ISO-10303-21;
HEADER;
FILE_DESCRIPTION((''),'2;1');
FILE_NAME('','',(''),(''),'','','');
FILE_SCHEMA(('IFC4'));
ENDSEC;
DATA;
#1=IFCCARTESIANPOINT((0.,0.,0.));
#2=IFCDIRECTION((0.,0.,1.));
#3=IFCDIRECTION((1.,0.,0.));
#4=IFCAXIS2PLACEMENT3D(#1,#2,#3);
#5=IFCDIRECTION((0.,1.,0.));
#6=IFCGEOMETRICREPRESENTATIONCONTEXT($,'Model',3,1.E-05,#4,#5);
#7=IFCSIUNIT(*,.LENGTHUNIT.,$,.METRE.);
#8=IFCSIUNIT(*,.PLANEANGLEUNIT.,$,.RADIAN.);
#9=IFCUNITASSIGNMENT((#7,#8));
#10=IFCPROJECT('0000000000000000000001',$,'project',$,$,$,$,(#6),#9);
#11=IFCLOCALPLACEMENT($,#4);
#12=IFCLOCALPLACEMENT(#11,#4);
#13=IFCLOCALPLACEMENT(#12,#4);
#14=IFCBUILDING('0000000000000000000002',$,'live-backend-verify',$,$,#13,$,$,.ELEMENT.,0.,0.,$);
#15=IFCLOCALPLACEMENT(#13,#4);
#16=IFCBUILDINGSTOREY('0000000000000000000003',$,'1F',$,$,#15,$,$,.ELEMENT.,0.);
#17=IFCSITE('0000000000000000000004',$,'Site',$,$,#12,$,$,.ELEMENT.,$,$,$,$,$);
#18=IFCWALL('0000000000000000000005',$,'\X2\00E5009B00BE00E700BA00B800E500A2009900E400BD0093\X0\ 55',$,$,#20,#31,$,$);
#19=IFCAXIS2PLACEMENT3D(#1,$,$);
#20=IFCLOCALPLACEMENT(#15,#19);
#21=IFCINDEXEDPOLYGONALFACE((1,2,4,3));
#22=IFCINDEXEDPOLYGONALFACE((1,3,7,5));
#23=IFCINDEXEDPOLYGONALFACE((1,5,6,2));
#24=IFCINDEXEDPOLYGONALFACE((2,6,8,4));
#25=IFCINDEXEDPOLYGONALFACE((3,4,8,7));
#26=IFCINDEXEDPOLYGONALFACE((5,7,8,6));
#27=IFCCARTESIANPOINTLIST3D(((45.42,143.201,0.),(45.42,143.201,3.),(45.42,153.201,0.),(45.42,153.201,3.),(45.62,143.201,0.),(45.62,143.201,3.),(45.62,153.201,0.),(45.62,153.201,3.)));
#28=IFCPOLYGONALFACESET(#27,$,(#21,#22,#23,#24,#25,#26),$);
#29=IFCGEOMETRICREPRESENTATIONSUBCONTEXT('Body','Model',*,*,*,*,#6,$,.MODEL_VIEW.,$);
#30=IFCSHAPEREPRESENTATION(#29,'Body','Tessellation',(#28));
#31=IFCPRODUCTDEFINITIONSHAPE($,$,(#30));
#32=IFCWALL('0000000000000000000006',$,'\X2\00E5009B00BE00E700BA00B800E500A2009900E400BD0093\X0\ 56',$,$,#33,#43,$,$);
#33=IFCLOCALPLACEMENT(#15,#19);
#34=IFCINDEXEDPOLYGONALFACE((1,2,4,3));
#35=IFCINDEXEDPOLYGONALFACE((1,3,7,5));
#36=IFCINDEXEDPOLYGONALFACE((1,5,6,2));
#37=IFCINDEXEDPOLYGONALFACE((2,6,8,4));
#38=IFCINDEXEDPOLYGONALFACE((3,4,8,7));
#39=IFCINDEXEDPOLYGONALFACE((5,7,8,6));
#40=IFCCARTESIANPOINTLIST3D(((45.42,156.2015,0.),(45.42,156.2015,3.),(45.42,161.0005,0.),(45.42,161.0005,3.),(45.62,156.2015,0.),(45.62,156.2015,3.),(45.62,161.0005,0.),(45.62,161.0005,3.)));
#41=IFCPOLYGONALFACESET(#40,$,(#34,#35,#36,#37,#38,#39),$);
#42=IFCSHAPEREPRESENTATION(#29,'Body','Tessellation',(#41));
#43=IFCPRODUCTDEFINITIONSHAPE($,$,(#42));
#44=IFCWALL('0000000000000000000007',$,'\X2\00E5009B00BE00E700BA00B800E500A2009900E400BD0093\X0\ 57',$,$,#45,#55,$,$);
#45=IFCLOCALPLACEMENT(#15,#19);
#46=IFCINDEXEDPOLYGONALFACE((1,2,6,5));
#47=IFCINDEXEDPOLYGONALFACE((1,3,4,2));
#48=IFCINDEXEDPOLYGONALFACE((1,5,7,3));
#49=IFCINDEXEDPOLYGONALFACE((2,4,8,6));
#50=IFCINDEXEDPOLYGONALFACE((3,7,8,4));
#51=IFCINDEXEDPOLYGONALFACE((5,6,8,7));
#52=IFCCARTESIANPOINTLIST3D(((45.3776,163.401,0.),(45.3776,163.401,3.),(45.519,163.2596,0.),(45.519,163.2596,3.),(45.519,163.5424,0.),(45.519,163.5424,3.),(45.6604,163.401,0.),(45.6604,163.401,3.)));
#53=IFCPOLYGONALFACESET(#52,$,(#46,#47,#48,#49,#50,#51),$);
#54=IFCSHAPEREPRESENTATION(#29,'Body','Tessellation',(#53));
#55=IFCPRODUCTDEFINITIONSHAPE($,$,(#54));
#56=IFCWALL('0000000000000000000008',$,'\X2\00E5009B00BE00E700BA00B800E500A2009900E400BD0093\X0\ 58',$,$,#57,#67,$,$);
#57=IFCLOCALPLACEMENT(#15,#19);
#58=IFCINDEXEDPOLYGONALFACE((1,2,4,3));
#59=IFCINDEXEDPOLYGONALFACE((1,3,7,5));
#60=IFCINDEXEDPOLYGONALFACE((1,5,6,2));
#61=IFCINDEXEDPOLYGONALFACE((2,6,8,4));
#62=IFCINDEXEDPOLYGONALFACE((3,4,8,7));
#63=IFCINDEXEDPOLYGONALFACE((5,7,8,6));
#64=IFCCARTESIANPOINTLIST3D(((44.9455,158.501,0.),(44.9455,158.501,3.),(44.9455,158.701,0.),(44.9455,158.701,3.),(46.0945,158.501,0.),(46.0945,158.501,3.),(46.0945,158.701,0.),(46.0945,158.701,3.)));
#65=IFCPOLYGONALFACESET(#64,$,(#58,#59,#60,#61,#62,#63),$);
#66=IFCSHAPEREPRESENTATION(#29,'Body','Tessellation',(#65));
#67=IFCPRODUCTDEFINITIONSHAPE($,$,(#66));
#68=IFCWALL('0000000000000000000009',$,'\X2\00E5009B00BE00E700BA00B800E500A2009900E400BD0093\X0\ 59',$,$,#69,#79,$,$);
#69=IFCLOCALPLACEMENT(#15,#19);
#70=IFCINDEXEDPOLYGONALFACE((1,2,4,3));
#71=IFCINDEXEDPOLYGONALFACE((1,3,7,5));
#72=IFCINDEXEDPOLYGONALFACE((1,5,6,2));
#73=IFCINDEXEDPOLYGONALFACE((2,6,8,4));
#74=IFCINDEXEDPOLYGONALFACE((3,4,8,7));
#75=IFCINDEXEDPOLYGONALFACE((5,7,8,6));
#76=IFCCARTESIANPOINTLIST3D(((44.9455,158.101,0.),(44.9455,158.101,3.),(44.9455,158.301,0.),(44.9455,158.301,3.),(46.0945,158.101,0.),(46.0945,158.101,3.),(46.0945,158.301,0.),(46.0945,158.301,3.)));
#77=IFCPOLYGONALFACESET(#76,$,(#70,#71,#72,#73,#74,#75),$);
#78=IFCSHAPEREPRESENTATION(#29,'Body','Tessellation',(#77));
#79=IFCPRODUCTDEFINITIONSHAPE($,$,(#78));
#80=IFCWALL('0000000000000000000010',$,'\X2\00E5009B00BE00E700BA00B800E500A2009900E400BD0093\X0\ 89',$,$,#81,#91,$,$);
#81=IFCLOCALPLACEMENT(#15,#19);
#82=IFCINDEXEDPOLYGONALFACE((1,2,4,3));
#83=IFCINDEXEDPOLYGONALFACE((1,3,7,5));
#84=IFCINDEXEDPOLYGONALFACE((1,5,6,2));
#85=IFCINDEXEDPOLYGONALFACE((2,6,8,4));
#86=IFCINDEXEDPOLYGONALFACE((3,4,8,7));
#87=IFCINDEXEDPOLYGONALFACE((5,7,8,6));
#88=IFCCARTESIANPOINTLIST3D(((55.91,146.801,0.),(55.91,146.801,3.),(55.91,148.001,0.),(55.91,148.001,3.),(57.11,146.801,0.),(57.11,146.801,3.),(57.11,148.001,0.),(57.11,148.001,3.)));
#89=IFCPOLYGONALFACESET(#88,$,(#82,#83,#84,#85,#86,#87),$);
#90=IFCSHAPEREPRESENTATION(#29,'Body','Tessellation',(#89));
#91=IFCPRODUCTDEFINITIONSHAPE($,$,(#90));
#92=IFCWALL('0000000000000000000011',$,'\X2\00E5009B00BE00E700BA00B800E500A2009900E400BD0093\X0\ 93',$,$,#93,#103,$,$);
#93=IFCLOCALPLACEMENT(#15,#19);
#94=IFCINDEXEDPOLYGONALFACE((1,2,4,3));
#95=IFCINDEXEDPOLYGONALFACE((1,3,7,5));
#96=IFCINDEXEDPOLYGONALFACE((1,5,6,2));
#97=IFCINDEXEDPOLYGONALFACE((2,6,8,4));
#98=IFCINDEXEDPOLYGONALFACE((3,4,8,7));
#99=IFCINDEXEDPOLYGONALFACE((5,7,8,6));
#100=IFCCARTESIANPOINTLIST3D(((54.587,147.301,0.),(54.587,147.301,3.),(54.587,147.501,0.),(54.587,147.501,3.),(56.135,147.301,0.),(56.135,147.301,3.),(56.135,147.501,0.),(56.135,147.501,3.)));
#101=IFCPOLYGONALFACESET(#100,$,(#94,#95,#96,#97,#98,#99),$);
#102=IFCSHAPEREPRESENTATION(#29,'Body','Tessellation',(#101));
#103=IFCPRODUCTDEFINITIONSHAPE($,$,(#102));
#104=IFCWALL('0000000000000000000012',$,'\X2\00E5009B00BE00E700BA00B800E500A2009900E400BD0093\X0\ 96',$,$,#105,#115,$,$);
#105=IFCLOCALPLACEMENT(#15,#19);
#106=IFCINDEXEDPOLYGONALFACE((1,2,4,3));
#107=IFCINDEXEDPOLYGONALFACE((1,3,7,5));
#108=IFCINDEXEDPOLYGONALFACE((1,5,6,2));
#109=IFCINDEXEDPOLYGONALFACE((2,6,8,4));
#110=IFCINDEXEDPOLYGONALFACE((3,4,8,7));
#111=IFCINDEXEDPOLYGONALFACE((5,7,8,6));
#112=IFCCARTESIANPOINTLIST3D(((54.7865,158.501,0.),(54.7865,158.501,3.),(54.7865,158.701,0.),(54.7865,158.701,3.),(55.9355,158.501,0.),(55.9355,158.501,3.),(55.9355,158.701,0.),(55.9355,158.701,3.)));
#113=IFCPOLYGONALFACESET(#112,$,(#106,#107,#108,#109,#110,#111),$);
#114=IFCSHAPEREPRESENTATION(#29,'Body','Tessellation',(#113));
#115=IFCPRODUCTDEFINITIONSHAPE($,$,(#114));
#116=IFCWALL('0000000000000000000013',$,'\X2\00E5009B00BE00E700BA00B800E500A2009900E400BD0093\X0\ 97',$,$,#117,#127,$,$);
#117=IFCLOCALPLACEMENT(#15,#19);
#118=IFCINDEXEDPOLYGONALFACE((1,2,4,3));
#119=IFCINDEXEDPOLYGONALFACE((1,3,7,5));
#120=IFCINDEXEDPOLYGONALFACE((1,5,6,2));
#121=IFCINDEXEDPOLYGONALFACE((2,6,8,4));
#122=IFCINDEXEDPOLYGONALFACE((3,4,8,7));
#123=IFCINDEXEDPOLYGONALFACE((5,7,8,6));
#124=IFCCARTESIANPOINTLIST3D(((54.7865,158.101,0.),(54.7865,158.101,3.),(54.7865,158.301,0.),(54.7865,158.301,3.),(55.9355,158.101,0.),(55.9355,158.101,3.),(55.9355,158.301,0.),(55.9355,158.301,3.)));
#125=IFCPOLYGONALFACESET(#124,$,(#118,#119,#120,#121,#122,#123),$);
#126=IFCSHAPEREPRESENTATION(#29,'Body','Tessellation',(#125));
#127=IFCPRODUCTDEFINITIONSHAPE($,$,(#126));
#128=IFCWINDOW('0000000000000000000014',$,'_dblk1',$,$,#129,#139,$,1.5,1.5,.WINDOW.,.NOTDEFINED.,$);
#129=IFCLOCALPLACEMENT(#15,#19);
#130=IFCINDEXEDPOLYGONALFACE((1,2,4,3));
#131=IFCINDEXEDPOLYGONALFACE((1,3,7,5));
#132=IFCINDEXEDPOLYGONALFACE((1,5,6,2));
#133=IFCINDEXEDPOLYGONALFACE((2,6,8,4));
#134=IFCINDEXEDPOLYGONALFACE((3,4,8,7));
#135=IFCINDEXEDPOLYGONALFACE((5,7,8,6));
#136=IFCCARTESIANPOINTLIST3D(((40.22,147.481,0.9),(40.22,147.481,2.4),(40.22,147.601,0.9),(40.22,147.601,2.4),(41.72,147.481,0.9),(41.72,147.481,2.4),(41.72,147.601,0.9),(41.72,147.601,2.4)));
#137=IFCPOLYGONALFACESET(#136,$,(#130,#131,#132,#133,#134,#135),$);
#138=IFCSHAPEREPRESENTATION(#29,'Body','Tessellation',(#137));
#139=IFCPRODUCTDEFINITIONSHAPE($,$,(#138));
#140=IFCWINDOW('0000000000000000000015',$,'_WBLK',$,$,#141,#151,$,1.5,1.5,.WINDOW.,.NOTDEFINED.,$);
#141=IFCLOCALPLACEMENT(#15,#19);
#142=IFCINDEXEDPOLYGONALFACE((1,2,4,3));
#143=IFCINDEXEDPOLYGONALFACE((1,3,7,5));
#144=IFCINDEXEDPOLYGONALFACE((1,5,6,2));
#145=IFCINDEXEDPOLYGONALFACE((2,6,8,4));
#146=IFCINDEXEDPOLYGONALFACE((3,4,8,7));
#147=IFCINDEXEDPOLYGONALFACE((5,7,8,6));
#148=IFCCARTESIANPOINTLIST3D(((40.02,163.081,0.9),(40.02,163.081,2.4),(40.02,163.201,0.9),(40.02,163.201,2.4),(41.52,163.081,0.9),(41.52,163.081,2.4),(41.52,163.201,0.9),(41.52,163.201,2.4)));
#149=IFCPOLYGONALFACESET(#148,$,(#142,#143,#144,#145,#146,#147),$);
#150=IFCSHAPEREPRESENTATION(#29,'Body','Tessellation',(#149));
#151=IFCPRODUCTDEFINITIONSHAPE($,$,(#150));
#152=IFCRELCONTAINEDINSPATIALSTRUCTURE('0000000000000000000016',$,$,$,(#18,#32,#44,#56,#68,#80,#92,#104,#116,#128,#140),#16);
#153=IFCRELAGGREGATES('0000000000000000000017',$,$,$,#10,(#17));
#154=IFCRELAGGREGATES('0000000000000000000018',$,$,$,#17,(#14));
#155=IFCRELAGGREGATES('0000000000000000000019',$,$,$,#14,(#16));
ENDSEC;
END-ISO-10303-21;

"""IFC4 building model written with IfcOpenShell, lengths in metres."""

from ifc_helpers import new_model, si_unit, direction, frame, frame_2d, origin_with_axes, place, context, subcontext, project, spatial, rectangle, extrude, element, save


model = new_model("IFC4")

# Units and contexts
model_context = context("Model", 3, precision=1e-05, world=origin_with_axes(), true_north=direction((0.0, 1.0, 0.0)))
body_context = subcontext(model_context, "Body", "Model", "MODEL_VIEW")
ifc_project = project(units=[si_unit("LENGTHUNIT", "METRE"), si_unit("PLANEANGLEUNIT", "RADIAN")], contexts=[model_context])

# Site, building, storey
placement = place(None, origin_with_axes())
site_placement = place(placement, origin_with_axes())
site = spatial("IfcSite", under=ifc_project, at=site_placement, Name="Site", CompositionType="ELEMENT")
building_placement = place(site_placement, origin_with_axes())
building = spatial("IfcBuilding", under=site, at=building_placement, Name="live-backend-verify", CompositionType="ELEMENT", ElevationOfRefHeight=0.0, ElevationOfTerrain=0.0)
storey_placement = place(building_placement, origin_with_axes())
storey = spatial("IfcBuildingStorey", under=building, at=storey_placement, Name="1F", CompositionType="ELEMENT", Elevation=0.0)

# Walls
wall_1_placement = place(storey_placement, frame((45.52, 148.201, 0.0), z_axis=(0.0, 0.0, 1.0), x_axis=(0.0, 1.0, 0.0)))
element("IfcWall", 1, at=wall_1_placement, inside=storey, Name="å\u009b¾çº¸å¢\u0099ä½\u0093 55", context=body_context, shape_type="SweptSolid", body=[
    extrude(rectangle(XDim=10.0, YDim=0.2, at=frame_2d((0.0, 0.0), x_axis=(1.0, 0.0, 0.0))), frame((0.0, 0.0, 0.0), z_axis=(0.0, 0.0, 1.0)), (0.0, 0.0, 1.0), 3.0),
])
wall_2_placement = place(storey_placement, frame((45.52, 158.601, 0.0), z_axis=(0.0, 0.0, 1.0), x_axis=(0.0, 1.0, 0.0)))
element("IfcWall", 2, at=wall_2_placement, inside=storey, Name="å\u009b¾çº¸å¢\u0099ä½\u0093 56", context=body_context, shape_type="SweptSolid", body=[
    extrude(rectangle(XDim=4.799, YDim=0.2, at=frame_2d((0.0, 0.0), x_axis=(1.0, 0.0, 0.0))), frame((0.0, 0.0, 0.0), z_axis=(0.0, 0.0, 1.0)), (0.0, 0.0, 1.0), 3.0),
])
wall_3_placement = place(storey_placement, frame((45.519, 163.401, 0.0), z_axis=(0.0, 0.0, 1.0), x_axis=(0.707107, -0.707107, 0.0)))
element("IfcWall", 3, at=wall_3_placement, inside=storey, Name="å\u009b¾çº¸å¢\u0099ä½\u0093 57", context=body_context, shape_type="SweptSolid", body=[
    extrude(rectangle(XDim=0.2, YDim=0.2, at=frame_2d((0.0, 0.0), x_axis=(1.0, 0.0, 0.0))), frame((0.0, 0.0, 0.0), z_axis=(0.0, 0.0, 1.0)), (0.0, 0.0, 1.0), 3.0),
])
for number, where, z_axis, x_axis, name in (
    (4, (45.52, 158.601, 0.0), (0.0, 0.0, 1.0), (1.0, 0.0, 0.0), "å\u009b¾çº¸å¢\u0099ä½\u0093 58"),
    (5, (45.52, 158.201, 0.0), (0.0, 0.0, 1.0), (1.0, 0.0, 0.0), "å\u009b¾çº¸å¢\u0099ä½\u0093 59"),
):
    element("IfcWall", number, at=place(storey_placement, frame(where, z_axis=z_axis, x_axis=x_axis)), inside=storey, Name=name, context=body_context, shape_type="SweptSolid", body=[
        extrude(rectangle(XDim=1.149, YDim=0.2, at=frame_2d((0.0, 0.0), x_axis=(1.0, 0.0, 0.0))), frame((0.0, 0.0, 0.0), z_axis=(0.0, 0.0, 1.0)), (0.0, 0.0, 1.0), 3.0),
    ])
wall_4_placement = place(storey_placement, frame((56.51, 147.401, 0.0), z_axis=(0.0, 0.0, 1.0), x_axis=(1.0, 0.0, 0.0)))
element("IfcWall", 6, at=wall_4_placement, inside=storey, Name="å\u009b¾çº¸å¢\u0099ä½\u0093 89", context=body_context, shape_type="SweptSolid", body=[
    extrude(rectangle(XDim=1.2, YDim=1.2, at=frame_2d((0.0, 0.0), x_axis=(1.0, 0.0, 0.0))), frame((0.0, 0.0, 0.0), z_axis=(0.0, 0.0, 1.0)), (0.0, 0.0, 1.0), 3.0),
])
wall_5_placement = place(storey_placement, frame((55.361, 147.401, 0.0), z_axis=(0.0, 0.0, 1.0), x_axis=(1.0, 0.0, 0.0)))
element("IfcWall", 7, at=wall_5_placement, inside=storey, Name="å\u009b¾çº¸å¢\u0099ä½\u0093 93", context=body_context, shape_type="SweptSolid", body=[
    extrude(rectangle(XDim=1.548, YDim=0.2, at=frame_2d((0.0, 0.0), x_axis=(1.0, 0.0, 0.0))), frame((0.0, 0.0, 0.0), z_axis=(0.0, 0.0, 1.0)), (0.0, 0.0, 1.0), 3.0),
])
for number, where, z_axis, x_axis, name in (
    (8, (55.361, 158.601, 0.0), (0.0, 0.0, 1.0), (1.0, 0.0, 0.0), "å\u009b¾çº¸å¢\u0099ä½\u0093 96"),
    (9, (55.361, 158.201, 0.0), (0.0, 0.0, 1.0), (1.0, 0.0, 0.0), "å\u009b¾çº¸å¢\u0099ä½\u0093 97"),
):
    element("IfcWall", number, at=place(storey_placement, frame(where, z_axis=z_axis, x_axis=x_axis)), inside=storey, Name=name, context=body_context, shape_type="SweptSolid", body=[
        extrude(rectangle(XDim=1.149, YDim=0.2, at=frame_2d((0.0, 0.0), x_axis=(1.0, 0.0, 0.0))), frame((0.0, 0.0, 0.0), z_axis=(0.0, 0.0, 1.0)), (0.0, 0.0, 1.0), 3.0),
    ])

# Windows
for number, where, z_axis, x_axis, name in (
    (10, (40.97, 147.541, 0.9), (0.0, 0.0, 1.0), (1.0, 0.0, 0.0), "_dblk1"),
    (11, (40.77, 163.141, 0.9), (0.0, 0.0, 1.0), (1.0, 0.0, 0.0), "_WBLK"),
):
    element("IfcWindow", number, at=place(storey_placement, frame(where, z_axis=z_axis, x_axis=x_axis)), inside=storey, Name=name, OverallHeight=1.5, OverallWidth=1.5, PartitioningType="NOTDEFINED", PredefinedType="WINDOW", context=body_context, shape_type="SweptSolid", body=[
        extrude(rectangle(XDim=1.5, YDim=0.12, at=frame_2d((0.0, 0.0), x_axis=(1.0, 0.0, 0.0))), frame((0.0, 0.0, 0.0), z_axis=(0.0, 0.0, 1.0)), (0.0, 0.0, 1.0), 1.5),
    ])

save(model, "model.ifc")
